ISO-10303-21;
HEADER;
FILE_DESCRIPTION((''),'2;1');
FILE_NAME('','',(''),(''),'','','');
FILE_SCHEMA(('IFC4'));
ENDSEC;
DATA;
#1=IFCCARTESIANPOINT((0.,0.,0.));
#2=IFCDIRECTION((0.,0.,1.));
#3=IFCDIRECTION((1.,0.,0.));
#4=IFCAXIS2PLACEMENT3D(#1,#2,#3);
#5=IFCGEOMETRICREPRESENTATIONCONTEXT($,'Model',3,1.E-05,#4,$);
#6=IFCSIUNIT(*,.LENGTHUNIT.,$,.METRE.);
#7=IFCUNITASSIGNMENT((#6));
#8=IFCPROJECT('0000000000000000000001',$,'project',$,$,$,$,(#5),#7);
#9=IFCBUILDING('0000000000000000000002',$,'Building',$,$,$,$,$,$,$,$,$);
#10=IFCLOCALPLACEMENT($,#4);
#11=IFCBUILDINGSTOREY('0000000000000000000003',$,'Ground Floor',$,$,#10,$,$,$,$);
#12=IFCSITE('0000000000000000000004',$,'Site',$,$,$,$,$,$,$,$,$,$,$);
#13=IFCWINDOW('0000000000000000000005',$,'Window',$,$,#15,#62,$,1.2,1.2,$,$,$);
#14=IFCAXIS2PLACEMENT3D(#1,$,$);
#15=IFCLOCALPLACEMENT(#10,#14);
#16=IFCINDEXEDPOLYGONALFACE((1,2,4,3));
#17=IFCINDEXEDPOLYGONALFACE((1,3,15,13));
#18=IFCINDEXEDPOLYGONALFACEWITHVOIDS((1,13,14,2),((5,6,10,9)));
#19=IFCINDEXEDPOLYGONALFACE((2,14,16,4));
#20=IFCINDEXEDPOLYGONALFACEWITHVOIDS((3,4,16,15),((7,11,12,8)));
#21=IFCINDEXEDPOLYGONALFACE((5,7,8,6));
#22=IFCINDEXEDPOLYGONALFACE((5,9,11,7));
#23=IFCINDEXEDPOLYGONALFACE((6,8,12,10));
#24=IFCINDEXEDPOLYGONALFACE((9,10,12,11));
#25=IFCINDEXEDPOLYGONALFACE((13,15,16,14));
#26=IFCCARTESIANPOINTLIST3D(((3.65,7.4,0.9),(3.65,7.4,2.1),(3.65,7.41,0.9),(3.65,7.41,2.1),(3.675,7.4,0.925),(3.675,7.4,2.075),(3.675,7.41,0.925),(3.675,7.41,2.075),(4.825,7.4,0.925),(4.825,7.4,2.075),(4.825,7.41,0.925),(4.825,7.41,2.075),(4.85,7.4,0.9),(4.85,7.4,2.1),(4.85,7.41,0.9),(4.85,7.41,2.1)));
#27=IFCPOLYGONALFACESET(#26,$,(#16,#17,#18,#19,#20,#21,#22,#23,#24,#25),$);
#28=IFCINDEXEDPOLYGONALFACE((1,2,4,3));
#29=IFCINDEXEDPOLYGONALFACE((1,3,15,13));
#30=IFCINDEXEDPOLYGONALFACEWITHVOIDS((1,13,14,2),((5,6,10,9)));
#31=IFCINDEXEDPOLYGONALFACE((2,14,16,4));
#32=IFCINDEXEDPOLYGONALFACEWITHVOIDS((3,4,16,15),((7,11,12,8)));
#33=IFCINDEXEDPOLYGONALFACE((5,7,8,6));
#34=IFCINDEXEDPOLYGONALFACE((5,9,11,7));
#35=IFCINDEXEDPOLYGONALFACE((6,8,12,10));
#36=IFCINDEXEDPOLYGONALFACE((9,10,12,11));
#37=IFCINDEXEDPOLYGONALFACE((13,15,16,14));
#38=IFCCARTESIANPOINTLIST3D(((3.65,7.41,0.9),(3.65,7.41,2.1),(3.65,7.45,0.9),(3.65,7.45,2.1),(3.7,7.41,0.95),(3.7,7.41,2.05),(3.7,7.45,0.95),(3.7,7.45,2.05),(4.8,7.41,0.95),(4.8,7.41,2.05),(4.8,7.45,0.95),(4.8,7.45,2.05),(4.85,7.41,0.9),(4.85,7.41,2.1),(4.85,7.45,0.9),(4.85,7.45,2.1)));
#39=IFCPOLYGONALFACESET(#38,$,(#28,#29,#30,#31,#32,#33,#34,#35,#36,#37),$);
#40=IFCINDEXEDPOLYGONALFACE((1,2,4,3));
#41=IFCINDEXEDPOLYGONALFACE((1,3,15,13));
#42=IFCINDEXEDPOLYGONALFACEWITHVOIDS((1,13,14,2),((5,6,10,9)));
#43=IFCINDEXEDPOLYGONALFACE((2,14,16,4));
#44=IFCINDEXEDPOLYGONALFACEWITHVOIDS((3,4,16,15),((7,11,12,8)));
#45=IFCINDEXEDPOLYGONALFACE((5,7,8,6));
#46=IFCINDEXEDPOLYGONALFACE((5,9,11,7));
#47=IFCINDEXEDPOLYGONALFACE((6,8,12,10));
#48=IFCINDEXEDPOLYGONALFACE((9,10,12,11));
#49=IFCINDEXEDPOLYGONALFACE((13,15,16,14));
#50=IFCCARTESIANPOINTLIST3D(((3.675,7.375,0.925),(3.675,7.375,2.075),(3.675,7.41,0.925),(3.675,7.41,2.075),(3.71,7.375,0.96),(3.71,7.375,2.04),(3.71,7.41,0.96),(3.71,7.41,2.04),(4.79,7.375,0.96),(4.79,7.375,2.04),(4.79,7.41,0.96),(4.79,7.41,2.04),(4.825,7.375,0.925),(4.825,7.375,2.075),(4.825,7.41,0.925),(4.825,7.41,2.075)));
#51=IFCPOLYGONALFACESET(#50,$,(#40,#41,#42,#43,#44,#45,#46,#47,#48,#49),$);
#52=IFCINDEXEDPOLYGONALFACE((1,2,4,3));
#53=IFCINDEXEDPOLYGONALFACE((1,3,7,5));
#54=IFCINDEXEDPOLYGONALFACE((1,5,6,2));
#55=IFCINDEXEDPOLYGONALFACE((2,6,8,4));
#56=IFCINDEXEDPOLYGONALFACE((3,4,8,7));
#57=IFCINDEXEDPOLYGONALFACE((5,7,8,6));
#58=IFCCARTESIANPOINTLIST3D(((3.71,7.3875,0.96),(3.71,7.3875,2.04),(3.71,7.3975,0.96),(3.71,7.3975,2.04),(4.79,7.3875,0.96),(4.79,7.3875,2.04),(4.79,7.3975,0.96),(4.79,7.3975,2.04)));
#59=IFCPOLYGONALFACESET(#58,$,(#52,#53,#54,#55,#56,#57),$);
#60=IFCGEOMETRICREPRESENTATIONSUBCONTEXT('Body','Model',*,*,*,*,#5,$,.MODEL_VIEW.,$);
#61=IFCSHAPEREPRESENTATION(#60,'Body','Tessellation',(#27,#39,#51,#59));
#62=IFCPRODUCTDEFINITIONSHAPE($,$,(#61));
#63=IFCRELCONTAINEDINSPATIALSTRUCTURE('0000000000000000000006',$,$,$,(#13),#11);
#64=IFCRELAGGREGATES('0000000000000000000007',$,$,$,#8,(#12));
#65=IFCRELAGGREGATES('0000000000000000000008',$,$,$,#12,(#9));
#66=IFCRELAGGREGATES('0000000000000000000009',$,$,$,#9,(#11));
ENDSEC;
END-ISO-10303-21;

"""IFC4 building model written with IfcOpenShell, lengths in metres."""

from ifc_helpers import new_model, si_unit, frame, origin_with_axes, place, context, subcontext, project, spatial, line, indexed_curve, outline, extrude, element, save


model = new_model("IFC4")

# Units and contexts
model_context = context("Model", 3, precision=1e-05, world=origin_with_axes())
body_context = subcontext(model_context, "Body", "Model", "MODEL_VIEW")
ifc_project = project(units=[si_unit("LENGTHUNIT", "METRE")], contexts=[model_context])

# Site, building, storey
site = spatial("IfcSite", under=ifc_project, Name="Site")
building = spatial("IfcBuilding", under=site, Name="Building")
storey_placement = place(None, origin_with_axes())
storey = spatial("IfcBuildingStorey", under=building, at=storey_placement, Name="Ground Floor")

# Window
for number, where, z_axis, x_axis, name in (
    (1, (4.85, 7.5, 0.9), (0.0, 0.0, 1.0), (-1.0, 0.0, 0.0), "Window"),
):
    element("IfcWindow", number, at=place(storey_placement, frame(where, z_axis=z_axis, x_axis=x_axis)), inside=storey, Name=name, OverallHeight=1.2, OverallWidth=1.2, context=body_context, shape_type="SweptSolid", body=[
        extrude(outline(indexed_curve([(0.0, 0.0), (1.2, 0.0), (1.2, 1.2), (0.0, 1.2)], segments=[line(1, 2, 3, 4, 1)]), holes=[indexed_curve([(0.025, 0.025), (1.175, 0.025), (1.175, 1.175), (0.025, 1.175)], segments=[line(1, 2, 3, 4, 1)])]), frame((0.0, 0.09, 0.0), z_axis=(0.0, -1.0, 0.0), x_axis=(1.0, 0.0, 0.0)), (0.0, 0.0, -1.0), 0.01),
        extrude(outline(indexed_curve([(0.0, 0.0), (1.2, 0.0), (1.2, 1.2), (0.0, 1.2)], segments=[line(1, 2, 3, 4, 1)]), holes=[indexed_curve([(0.05, 0.05), (1.15, 0.05), (1.15, 1.15), (0.05, 1.15)], segments=[line(1, 2, 3, 4, 1)])]), frame((0.0, 0.05, 0.0), z_axis=(0.0, -1.0, 0.0), x_axis=(1.0, 0.0, 0.0)), (0.0, 0.0, -1.0), 0.04),
        extrude(outline(indexed_curve([(0.0, 0.0), (1.15, 0.0), (1.15, 1.15), (0.0, 1.15)], segments=[line(1, 2, 3, 4, 1)]), holes=[indexed_curve([(0.035, 0.035), (1.115, 0.035), (1.115, 1.115), (0.035, 1.115)], segments=[line(1, 2, 3, 4, 1)])]), frame((0.025, 0.09, 0.025), z_axis=(0.0, -1.0, 0.0), x_axis=(1.0, 0.0, 0.0)), (0.0, 0.0, -1.0), 0.035),
        extrude(outline(indexed_curve([(0.035, 0.035), (1.115, 0.035), (1.115, 1.115), (0.035, 1.115)], segments=[line(1, 2, 3, 4, 1)])), frame((0.025, 0.1025, 0.025), z_axis=(0.0, -1.0, 0.0), x_axis=(1.0, 0.0, 0.0)), (0.0, 0.0, -1.0), 0.01),
    ])

save(model, "model.ifc")
